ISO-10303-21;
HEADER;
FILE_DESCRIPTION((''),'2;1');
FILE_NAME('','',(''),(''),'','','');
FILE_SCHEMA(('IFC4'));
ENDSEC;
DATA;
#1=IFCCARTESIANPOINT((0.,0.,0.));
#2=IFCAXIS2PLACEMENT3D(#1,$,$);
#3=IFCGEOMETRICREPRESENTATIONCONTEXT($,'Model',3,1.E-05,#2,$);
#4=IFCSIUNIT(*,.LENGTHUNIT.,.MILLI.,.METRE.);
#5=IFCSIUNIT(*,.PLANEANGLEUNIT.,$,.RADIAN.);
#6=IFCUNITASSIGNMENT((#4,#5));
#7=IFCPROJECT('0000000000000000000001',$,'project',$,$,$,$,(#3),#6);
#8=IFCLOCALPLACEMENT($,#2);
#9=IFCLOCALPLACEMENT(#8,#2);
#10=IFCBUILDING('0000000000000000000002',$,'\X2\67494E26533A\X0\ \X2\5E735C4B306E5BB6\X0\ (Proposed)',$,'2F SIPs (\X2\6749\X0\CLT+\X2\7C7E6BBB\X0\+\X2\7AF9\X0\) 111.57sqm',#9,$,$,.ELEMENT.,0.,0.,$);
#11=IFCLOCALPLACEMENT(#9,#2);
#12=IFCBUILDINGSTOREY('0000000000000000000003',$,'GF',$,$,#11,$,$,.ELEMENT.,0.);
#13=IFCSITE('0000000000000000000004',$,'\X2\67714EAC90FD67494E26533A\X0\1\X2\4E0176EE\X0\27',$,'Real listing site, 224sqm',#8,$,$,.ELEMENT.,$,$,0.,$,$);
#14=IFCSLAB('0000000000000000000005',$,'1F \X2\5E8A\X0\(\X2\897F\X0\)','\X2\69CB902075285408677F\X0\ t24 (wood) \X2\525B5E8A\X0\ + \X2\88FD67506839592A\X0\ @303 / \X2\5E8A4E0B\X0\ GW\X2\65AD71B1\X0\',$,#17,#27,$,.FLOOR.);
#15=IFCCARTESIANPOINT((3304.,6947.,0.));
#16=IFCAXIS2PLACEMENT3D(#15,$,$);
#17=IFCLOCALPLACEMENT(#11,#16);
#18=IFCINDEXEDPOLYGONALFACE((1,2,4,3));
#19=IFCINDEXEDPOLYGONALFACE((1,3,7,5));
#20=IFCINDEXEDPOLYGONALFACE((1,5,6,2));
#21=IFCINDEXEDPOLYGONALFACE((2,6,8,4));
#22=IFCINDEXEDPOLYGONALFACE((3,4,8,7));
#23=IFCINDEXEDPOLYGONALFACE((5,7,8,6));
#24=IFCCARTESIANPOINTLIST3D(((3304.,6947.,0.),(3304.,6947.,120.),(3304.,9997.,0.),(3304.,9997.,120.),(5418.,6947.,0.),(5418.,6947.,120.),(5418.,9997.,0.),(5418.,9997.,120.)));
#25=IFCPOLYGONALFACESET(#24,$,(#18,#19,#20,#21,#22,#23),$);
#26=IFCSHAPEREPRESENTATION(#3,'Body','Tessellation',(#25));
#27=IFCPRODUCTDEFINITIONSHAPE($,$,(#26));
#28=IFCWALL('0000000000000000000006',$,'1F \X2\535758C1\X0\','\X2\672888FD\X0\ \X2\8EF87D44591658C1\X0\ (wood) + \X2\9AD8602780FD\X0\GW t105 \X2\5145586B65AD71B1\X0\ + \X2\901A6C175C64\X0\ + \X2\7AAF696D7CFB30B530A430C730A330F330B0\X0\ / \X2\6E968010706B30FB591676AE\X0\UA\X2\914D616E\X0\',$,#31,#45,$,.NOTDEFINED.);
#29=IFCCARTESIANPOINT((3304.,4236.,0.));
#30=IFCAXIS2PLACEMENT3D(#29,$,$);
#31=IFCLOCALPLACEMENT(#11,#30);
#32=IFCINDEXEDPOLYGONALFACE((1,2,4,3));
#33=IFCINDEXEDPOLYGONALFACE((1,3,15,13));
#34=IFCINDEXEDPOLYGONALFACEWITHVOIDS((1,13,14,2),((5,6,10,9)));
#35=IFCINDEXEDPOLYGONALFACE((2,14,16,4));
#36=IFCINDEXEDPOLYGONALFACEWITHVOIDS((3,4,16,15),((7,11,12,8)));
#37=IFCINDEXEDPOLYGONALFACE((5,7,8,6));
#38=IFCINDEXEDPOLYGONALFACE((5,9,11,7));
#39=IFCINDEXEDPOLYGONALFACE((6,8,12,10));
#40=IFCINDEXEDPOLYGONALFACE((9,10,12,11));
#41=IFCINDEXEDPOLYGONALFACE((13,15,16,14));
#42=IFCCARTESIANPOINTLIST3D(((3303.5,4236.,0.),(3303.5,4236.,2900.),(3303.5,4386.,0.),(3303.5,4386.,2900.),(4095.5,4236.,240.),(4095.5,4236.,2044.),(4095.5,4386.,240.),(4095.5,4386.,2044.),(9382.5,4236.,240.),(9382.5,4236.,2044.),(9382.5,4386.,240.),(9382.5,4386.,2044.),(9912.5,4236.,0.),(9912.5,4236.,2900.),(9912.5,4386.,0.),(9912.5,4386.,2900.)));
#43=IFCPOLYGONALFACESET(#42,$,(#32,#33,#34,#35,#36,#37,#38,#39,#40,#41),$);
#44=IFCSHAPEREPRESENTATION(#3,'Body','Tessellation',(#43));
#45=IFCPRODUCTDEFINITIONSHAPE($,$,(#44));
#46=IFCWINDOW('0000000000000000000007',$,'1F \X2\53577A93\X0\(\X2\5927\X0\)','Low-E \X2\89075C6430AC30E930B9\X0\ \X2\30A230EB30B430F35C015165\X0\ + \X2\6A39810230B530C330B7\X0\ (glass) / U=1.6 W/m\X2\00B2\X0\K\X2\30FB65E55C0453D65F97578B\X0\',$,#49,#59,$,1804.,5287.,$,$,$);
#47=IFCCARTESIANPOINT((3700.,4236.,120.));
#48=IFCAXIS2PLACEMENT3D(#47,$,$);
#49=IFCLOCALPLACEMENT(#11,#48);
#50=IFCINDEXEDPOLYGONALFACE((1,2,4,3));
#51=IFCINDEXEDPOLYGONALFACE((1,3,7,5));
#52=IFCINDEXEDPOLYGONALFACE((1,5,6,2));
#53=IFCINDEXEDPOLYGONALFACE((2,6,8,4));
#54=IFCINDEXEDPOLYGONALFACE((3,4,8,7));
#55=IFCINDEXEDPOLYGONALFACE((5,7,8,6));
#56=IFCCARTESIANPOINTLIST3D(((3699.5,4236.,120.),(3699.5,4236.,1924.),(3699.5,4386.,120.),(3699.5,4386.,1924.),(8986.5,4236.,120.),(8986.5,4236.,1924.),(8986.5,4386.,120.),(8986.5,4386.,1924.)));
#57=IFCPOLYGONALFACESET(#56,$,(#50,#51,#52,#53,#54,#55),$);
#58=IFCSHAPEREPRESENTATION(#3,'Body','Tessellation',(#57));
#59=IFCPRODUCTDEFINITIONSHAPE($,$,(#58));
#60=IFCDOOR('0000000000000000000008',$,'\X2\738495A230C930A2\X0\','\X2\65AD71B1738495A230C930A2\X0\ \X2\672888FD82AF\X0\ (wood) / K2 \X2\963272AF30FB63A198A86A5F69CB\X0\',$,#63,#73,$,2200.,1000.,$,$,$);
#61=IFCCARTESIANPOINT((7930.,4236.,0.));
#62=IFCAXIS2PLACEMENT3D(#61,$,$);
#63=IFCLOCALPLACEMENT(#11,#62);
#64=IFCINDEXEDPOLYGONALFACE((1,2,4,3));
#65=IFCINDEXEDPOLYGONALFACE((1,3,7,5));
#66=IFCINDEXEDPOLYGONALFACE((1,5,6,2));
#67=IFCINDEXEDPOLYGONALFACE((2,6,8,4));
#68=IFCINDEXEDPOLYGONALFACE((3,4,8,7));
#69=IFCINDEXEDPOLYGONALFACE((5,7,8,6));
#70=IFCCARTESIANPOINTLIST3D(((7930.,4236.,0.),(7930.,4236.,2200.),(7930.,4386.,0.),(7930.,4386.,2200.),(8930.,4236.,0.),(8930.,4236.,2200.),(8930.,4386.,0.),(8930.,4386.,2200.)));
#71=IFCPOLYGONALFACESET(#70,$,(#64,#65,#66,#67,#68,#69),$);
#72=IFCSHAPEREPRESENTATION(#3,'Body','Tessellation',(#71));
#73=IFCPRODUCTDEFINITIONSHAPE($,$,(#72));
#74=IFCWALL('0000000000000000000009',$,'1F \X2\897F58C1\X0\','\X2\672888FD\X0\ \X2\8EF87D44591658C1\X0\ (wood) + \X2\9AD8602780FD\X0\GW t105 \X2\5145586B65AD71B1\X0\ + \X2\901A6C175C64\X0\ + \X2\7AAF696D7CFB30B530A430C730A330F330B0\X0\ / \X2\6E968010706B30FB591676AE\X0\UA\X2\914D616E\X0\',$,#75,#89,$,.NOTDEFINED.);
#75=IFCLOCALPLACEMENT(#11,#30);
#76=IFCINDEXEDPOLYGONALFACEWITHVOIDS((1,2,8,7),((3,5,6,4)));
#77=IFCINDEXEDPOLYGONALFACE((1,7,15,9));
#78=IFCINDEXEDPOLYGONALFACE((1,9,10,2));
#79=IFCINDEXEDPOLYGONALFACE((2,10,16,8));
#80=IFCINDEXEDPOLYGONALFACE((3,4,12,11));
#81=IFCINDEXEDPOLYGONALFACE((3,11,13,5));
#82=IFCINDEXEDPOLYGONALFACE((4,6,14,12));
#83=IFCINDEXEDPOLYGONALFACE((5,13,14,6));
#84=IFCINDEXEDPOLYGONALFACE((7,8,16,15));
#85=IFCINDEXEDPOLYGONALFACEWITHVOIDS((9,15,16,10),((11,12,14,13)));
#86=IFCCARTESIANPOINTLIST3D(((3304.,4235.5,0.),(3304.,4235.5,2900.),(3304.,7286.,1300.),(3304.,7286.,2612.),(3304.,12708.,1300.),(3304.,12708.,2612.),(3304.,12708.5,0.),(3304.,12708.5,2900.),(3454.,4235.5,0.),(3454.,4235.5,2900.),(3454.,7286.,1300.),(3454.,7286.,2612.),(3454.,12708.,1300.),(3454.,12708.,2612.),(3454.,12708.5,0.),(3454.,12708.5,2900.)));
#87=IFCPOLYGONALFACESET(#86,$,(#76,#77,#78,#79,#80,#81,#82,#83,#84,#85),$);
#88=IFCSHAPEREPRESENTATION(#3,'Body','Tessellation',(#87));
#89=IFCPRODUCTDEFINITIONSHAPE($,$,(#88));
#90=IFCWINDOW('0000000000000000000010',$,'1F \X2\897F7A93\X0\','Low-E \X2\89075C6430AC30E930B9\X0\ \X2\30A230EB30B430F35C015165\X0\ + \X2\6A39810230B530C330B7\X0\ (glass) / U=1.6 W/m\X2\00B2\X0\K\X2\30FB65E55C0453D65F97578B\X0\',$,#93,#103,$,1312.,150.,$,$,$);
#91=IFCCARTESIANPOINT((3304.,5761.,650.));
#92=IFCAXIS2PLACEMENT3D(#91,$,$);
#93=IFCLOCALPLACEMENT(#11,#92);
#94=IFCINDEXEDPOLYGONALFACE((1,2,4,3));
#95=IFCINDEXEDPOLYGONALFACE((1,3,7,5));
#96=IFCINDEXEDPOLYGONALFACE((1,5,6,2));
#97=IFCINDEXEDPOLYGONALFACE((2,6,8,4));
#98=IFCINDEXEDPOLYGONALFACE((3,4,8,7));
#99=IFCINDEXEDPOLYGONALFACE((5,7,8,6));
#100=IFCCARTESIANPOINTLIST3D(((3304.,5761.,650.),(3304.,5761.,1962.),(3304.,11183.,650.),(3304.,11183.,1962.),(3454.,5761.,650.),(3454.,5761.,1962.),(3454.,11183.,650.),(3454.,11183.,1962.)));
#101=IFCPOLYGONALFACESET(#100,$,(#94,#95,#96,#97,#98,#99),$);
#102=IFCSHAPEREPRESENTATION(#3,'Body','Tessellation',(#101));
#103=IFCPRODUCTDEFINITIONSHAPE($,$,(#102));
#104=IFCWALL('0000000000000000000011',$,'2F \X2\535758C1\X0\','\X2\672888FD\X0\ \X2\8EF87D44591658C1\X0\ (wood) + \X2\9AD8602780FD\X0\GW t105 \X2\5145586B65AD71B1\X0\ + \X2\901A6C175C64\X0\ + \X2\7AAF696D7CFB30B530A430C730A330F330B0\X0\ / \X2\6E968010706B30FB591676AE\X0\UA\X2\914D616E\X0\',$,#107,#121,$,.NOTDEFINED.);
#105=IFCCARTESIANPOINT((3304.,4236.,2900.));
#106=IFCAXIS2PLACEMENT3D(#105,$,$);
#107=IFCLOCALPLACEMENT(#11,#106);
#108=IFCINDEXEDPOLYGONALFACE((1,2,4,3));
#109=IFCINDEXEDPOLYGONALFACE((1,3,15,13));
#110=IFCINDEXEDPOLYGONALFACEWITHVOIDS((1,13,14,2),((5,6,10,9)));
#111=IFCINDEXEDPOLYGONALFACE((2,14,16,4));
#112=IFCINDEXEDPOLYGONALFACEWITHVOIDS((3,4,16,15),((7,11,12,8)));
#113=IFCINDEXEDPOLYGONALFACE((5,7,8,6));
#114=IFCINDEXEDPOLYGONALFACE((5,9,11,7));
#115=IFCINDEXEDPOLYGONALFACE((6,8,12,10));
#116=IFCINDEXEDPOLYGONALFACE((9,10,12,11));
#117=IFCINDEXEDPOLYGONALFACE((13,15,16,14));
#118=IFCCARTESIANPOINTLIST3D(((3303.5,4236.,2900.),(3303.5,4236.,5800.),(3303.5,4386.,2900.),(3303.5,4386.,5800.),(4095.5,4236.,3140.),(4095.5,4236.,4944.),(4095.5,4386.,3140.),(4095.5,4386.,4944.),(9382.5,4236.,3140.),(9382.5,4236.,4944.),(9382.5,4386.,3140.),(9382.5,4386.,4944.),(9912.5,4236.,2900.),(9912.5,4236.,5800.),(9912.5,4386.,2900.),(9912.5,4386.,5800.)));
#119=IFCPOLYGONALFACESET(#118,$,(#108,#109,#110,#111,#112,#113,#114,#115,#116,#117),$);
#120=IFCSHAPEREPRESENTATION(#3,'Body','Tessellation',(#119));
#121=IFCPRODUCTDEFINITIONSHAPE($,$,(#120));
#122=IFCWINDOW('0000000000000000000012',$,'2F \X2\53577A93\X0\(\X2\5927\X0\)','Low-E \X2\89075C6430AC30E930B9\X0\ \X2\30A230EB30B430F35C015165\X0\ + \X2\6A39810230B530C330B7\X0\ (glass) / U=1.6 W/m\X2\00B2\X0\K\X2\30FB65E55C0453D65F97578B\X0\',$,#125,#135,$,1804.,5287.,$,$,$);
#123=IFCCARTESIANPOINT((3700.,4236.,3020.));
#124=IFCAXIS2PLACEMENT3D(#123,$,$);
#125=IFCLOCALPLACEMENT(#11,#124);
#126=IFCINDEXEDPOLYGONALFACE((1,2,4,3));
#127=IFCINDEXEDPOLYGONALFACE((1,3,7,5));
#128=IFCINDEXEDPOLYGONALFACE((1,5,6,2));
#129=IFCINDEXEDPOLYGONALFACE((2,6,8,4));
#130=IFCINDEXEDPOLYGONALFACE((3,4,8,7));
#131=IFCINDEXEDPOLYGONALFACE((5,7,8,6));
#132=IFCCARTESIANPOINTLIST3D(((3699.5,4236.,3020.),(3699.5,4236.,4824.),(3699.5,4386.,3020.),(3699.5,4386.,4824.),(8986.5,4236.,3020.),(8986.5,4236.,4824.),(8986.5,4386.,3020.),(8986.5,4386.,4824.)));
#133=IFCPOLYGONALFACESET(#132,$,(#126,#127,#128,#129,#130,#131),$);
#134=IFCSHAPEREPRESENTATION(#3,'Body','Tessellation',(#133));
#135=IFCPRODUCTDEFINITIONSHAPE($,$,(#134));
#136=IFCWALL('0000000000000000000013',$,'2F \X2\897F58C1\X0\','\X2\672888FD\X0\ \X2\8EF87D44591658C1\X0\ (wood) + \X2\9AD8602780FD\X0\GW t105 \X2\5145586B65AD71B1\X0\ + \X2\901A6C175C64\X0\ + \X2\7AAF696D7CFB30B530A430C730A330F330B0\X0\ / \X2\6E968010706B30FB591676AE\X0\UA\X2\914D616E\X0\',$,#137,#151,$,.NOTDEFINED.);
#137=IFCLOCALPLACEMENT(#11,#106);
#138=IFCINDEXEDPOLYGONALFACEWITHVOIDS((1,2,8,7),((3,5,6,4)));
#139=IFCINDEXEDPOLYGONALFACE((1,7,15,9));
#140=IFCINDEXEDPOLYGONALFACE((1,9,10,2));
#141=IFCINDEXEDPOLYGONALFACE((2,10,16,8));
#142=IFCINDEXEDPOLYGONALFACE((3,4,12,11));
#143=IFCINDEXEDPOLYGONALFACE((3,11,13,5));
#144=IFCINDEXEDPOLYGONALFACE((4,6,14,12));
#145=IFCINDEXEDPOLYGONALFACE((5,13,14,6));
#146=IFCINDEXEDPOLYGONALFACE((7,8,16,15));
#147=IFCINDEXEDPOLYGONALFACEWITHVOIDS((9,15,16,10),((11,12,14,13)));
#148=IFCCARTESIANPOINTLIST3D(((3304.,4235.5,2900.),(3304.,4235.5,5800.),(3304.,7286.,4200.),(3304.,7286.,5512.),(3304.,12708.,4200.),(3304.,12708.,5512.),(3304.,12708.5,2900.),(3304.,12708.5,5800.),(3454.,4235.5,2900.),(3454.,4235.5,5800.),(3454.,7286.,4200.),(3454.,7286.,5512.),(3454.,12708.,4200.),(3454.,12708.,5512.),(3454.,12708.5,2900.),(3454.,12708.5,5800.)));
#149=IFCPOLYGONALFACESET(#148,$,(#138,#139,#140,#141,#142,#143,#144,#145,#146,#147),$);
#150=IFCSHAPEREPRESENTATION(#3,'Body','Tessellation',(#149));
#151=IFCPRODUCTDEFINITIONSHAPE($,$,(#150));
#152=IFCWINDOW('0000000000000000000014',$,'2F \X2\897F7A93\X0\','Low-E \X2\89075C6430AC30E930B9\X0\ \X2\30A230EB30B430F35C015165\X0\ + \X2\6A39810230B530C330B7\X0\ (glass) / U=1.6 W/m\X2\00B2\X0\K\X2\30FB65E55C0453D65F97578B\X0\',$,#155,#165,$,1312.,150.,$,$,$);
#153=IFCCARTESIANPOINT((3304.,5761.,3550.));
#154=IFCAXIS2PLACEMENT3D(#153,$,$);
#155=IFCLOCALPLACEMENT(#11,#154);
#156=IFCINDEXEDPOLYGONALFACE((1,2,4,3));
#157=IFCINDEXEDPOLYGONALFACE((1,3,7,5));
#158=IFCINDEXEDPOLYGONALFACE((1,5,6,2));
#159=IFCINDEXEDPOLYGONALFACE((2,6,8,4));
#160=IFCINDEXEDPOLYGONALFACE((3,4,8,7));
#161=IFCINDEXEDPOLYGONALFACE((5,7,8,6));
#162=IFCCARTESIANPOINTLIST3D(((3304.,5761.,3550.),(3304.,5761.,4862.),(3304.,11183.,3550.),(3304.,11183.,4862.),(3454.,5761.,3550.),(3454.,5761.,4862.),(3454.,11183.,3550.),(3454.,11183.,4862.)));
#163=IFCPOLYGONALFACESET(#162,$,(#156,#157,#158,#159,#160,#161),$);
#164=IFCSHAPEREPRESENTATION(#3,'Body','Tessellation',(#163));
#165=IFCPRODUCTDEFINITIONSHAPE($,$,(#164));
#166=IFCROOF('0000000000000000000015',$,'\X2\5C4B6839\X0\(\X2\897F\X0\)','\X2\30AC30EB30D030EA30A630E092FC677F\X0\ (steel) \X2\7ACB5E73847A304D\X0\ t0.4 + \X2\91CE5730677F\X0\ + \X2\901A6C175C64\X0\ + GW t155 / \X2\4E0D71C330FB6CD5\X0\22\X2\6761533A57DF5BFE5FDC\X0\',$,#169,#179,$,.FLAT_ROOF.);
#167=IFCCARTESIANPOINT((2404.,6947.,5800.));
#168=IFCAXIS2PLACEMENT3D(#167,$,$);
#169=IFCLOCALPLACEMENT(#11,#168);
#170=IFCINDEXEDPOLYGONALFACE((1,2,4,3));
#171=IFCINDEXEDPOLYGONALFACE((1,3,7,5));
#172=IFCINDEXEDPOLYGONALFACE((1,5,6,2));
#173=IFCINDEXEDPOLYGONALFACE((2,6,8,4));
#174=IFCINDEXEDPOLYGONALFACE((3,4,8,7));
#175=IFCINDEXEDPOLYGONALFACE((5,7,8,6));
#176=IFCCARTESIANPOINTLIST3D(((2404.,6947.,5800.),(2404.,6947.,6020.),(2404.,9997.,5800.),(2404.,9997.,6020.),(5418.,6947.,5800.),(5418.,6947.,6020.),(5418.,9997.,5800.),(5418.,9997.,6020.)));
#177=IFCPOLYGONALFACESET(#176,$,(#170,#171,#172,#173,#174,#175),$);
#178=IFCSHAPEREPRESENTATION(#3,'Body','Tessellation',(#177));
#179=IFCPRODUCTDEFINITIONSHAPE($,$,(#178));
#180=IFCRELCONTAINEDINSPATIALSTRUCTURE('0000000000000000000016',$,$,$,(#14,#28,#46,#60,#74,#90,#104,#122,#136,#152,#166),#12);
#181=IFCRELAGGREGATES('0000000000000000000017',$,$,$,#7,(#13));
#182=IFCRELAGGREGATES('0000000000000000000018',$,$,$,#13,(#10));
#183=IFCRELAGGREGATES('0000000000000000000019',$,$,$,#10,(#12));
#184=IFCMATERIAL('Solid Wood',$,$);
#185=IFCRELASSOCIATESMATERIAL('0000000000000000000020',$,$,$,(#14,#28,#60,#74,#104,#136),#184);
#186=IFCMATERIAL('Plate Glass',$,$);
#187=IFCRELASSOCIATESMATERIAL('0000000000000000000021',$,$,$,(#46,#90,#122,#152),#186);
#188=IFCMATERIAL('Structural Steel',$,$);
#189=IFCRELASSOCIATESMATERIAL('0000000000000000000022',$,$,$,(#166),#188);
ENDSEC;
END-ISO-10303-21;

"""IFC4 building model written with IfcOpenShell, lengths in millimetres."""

from ifc_helpers import new_model, si_unit, frame, frame_2d, origin, place, context, project, spatial, rectangle, extrude, material, element, fill, save


model = new_model("IFC4")

# Units and contexts
model_context = context("Model", 3, precision=1e-05, world=origin())
ifc_project = project(units=[si_unit("LENGTHUNIT", "METRE", prefix="MILLI"), si_unit("PLANEANGLEUNIT", "RADIAN")], contexts=[model_context])

# Site, building, storey
site_placement = place(None, origin())
site = spatial("IfcSite", under=ifc_project, at=site_placement, Name="東京都杉並区1丁目27", ObjectType="Real listing site, 224sqm", CompositionType="ELEMENT", RefElevation=0.0)
building_placement = place(site_placement, origin())
building = spatial("IfcBuilding", under=site, at=building_placement, Name="杉並区 平屋の家 (Proposed)", ObjectType="2F SIPs (杉CLT+籾殻+竹) 111.57sqm", CompositionType="ELEMENT", ElevationOfRefHeight=0.0, ElevationOfTerrain=0.0)
storey_placement = place(building_placement, origin())
storey = spatial("IfcBuildingStorey", under=building, at=storey_placement, Name="GF", CompositionType="ELEMENT", Elevation=0.0)

# Slab
ifc_material_1 = material(Name="Solid Wood")
slab_1_placement = place(storey_placement, frame((3304.0, 6947.0, 0.0)))
element("IfcSlab", 1, at=slab_1_placement, inside=storey, material=ifc_material_1, Name="1F 床(西)", Description="構造用合板 t24 (wood) 剛床 + 製材根太 @303 / 床下 GW断熱", PredefinedType="FLOOR", context=model_context, shape_type="SweptSolid", body=[
    extrude(rectangle(XDim=2114.0, YDim=3050.0, at=frame_2d((1057.0, 1525.0))), frame((3304.0, 6947.0, 0.0)), (0.0, 0.0, 1.0), 120.0),
])

# Wall, openings, window, door
wall_1_placement = place(storey_placement, frame((3304.0, 4236.0, 0.0)))
wall_1 = element("IfcWall", 2, at=wall_1_placement, inside=storey, material=ifc_material_1, Name="1F 南壁", Description="木製 軸組外壁 (wood) + 高性能GW t105 充填断熱 + 通気層 + 窯業系サイディング / 準耐火・外皮UA配慮", PredefinedType="NOTDEFINED", context=model_context, shape_type="SweptSolid", body=[
    extrude(rectangle(XDim=6609.0, YDim=150.0, at=frame_2d((3304.0, 75.0))), frame((3304.0, 4236.0, 0.0)), (0.0, 0.0, 1.0), 2900.0),
])
opening_1_placement = place(storey_placement, frame((3700.0, 4236.0, 120.0)))
opening_1 = element("IfcOpeningElement", 3, at=opening_1_placement, cuts=wall_1, PredefinedType="NOTDEFINED", context=model_context, shape_type="SweptSolid", body=[
    extrude(rectangle(XDim=5287.0, YDim=150.0, at=frame_2d((2643.0, 75.0))), frame((3700.0, 4236.0, 120.0)), (0.0, 0.0, 1.0), 1804.0),
])
opening_2_placement = place(storey_placement, frame((7930.0, 4236.0, 0.0)))
opening_2 = element("IfcOpeningElement", 4, at=opening_2_placement, cuts=wall_1, PredefinedType="NOTDEFINED", context=model_context, shape_type="SweptSolid", body=[
    extrude(rectangle(XDim=1000.0, YDim=150.0, at=frame_2d((500.0, 75.0))), frame((7930.0, 4236.0, 0.0)), (0.0, 0.0, 1.0), 2200.0),
])
ifc_material_2 = material(Name="Plate Glass")
window_1_placement = place(storey_placement, frame((3700.0, 4236.0, 120.0)))
window_1 = element("IfcWindow", 5, at=window_1_placement, inside=storey, material=ifc_material_2, Name="1F 南窓(大)", Description="Low-E 複層ガラス アルゴン封入 + 樹脂サッシ (glass) / U=1.6 W/m²K・日射取得型", OverallHeight=1804.0, OverallWidth=5287.0, context=model_context, shape_type="SweptSolid", body=[
    extrude(rectangle(XDim=5287.0, YDim=150.0, at=frame_2d((2643.0, 75.0))), frame((3700.0, 4236.0, 120.0)), (0.0, 0.0, 1.0), 1804.0),
])
fill(opening_1, window_1)
door_placement = place(storey_placement, frame((7930.0, 4236.0, 0.0)))
door = element("IfcDoor", 6, at=door_placement, inside=storey, material=ifc_material_1, Name="玄関ドア", Description="断熱玄関ドア 木製芯 (wood) / K2 防犯・採風機構", OverallHeight=2200.0, OverallWidth=1000.0, context=model_context, shape_type="SweptSolid", body=[
    extrude(rectangle(XDim=1000.0, YDim=150.0, at=frame_2d((500.0, 75.0))), frame((7930.0, 4236.0, 0.0)), (0.0, 0.0, 1.0), 2200.0),
])
fill(opening_2, door)

# Walls, openings, windows
wall_2_placement = place(storey_placement, frame((3304.0, 4236.0, 0.0)))
wall_2 = element("IfcWall", 7, at=wall_2_placement, inside=storey, material=ifc_material_1, Name="1F 西壁", Description="木製 軸組外壁 (wood) + 高性能GW t105 充填断熱 + 通気層 + 窯業系サイディング / 準耐火・外皮UA配慮", PredefinedType="NOTDEFINED", context=model_context, shape_type="SweptSolid", body=[
    extrude(rectangle(XDim=150.0, YDim=8473.0, at=frame_2d((75.0, 4236.0))), frame((3304.0, 4236.0, 0.0)), (0.0, 0.0, 1.0), 2900.0),
])
opening_3_placement = place(storey_placement, frame((3304.0, 5761.0, 650.0)))
opening_3 = element("IfcOpeningElement", 8, at=opening_3_placement, cuts=wall_2, PredefinedType="NOTDEFINED", context=model_context, shape_type="SweptSolid", body=[
    extrude(rectangle(XDim=150.0, YDim=5422.0, at=frame_2d((75.0, 2711.0))), frame((3304.0, 5761.0, 650.0)), (0.0, 0.0, 1.0), 1312.0),
])
window_2_placement = place(storey_placement, frame((3304.0, 5761.0, 650.0)))
window_2 = element("IfcWindow", 9, at=window_2_placement, inside=storey, material=ifc_material_2, Name="1F 西窓", Description="Low-E 複層ガラス アルゴン封入 + 樹脂サッシ (glass) / U=1.6 W/m²K・日射取得型", OverallHeight=1312.0, OverallWidth=150.0, context=model_context, shape_type="SweptSolid", body=[
    extrude(rectangle(XDim=150.0, YDim=5422.0, at=frame_2d((75.0, 2711.0))), frame((3304.0, 5761.0, 650.0)), (0.0, 0.0, 1.0), 1312.0),
])
fill(opening_3, window_2)
wall_3_placement = place(storey_placement, frame((3304.0, 4236.0, 2900.0)))
wall_3 = element("IfcWall", 10, at=wall_3_placement, inside=storey, material=ifc_material_1, Name="2F 南壁", Description="木製 軸組外壁 (wood) + 高性能GW t105 充填断熱 + 通気層 + 窯業系サイディング / 準耐火・外皮UA配慮", PredefinedType="NOTDEFINED", context=model_context, shape_type="SweptSolid", body=[
    extrude(rectangle(XDim=6609.0, YDim=150.0, at=frame_2d((3304.0, 75.0))), frame((3304.0, 4236.0, 2900.0)), (0.0, 0.0, 1.0), 2900.0),
])
opening_4_placement = place(storey_placement, frame((3700.0, 4236.0, 3020.0)))
opening_4 = element("IfcOpeningElement", 11, at=opening_4_placement, cuts=wall_3, PredefinedType="NOTDEFINED", context=model_context, shape_type="SweptSolid", body=[
    extrude(rectangle(XDim=5287.0, YDim=150.0, at=frame_2d((2643.0, 75.0))), frame((3700.0, 4236.0, 3020.0)), (0.0, 0.0, 1.0), 1804.0),
])
window_3_placement = place(storey_placement, frame((3700.0, 4236.0, 3020.0)))
window_3 = element("IfcWindow", 12, at=window_3_placement, inside=storey, material=ifc_material_2, Name="2F 南窓(大)", Description="Low-E 複層ガラス アルゴン封入 + 樹脂サッシ (glass) / U=1.6 W/m²K・日射取得型", OverallHeight=1804.0, OverallWidth=5287.0, context=model_context, shape_type="SweptSolid", body=[
    extrude(rectangle(XDim=5287.0, YDim=150.0, at=frame_2d((2643.0, 75.0))), frame((3700.0, 4236.0, 3020.0)), (0.0, 0.0, 1.0), 1804.0),
])
fill(opening_4, window_3)
wall_4_placement = place(storey_placement, frame((3304.0, 4236.0, 2900.0)))
wall_4 = element("IfcWall", 13, at=wall_4_placement, inside=storey, material=ifc_material_1, Name="2F 西壁", Description="木製 軸組外壁 (wood) + 高性能GW t105 充填断熱 + 通気層 + 窯業系サイディング / 準耐火・外皮UA配慮", PredefinedType="NOTDEFINED", context=model_context, shape_type="SweptSolid", body=[
    extrude(rectangle(XDim=150.0, YDim=8473.0, at=frame_2d((75.0, 4236.0))), frame((3304.0, 4236.0, 2900.0)), (0.0, 0.0, 1.0), 2900.0),
])
opening_5_placement = place(storey_placement, frame((3304.0, 5761.0, 3550.0)))
opening_5 = element("IfcOpeningElement", 14, at=opening_5_placement, cuts=wall_4, PredefinedType="NOTDEFINED", context=model_context, shape_type="SweptSolid", body=[
    extrude(rectangle(XDim=150.0, YDim=5422.0, at=frame_2d((75.0, 2711.0))), frame((3304.0, 5761.0, 3550.0)), (0.0, 0.0, 1.0), 1312.0),
])
window_4_placement = place(storey_placement, frame((3304.0, 5761.0, 3550.0)))
window_4 = element("IfcWindow", 15, at=window_4_placement, inside=storey, material=ifc_material_2, Name="2F 西窓", Description="Low-E 複層ガラス アルゴン封入 + 樹脂サッシ (glass) / U=1.6 W/m²K・日射取得型", OverallHeight=1312.0, OverallWidth=150.0, context=model_context, shape_type="SweptSolid", body=[
    extrude(rectangle(XDim=150.0, YDim=5422.0, at=frame_2d((75.0, 2711.0))), frame((3304.0, 5761.0, 3550.0)), (0.0, 0.0, 1.0), 1312.0),
])
fill(opening_5, window_4)

# Roof
ifc_material_3 = material(Name="Structural Steel")
roof_1_placement = place(storey_placement, frame((2404.0, 6947.0, 5800.0)))
element("IfcRoof", 16, at=roof_1_placement, inside=storey, material=ifc_material_3, Name="屋根(西)", Description="ガルバリウム鋼板 (steel) 立平葺き t0.4 + 野地板 + 通気層 + GW t155 / 不燃・法22条区域対応", PredefinedType="FLAT_ROOF", context=model_context, shape_type="SweptSolid", body=[
    extrude(rectangle(XDim=3014.0, YDim=3050.0, at=frame_2d((1507.0, 1525.0))), frame((2404.0, 6947.0, 5800.0)), (0.0, 0.0, 1.0), 220.0),
])

save(model, "model.ifc")
